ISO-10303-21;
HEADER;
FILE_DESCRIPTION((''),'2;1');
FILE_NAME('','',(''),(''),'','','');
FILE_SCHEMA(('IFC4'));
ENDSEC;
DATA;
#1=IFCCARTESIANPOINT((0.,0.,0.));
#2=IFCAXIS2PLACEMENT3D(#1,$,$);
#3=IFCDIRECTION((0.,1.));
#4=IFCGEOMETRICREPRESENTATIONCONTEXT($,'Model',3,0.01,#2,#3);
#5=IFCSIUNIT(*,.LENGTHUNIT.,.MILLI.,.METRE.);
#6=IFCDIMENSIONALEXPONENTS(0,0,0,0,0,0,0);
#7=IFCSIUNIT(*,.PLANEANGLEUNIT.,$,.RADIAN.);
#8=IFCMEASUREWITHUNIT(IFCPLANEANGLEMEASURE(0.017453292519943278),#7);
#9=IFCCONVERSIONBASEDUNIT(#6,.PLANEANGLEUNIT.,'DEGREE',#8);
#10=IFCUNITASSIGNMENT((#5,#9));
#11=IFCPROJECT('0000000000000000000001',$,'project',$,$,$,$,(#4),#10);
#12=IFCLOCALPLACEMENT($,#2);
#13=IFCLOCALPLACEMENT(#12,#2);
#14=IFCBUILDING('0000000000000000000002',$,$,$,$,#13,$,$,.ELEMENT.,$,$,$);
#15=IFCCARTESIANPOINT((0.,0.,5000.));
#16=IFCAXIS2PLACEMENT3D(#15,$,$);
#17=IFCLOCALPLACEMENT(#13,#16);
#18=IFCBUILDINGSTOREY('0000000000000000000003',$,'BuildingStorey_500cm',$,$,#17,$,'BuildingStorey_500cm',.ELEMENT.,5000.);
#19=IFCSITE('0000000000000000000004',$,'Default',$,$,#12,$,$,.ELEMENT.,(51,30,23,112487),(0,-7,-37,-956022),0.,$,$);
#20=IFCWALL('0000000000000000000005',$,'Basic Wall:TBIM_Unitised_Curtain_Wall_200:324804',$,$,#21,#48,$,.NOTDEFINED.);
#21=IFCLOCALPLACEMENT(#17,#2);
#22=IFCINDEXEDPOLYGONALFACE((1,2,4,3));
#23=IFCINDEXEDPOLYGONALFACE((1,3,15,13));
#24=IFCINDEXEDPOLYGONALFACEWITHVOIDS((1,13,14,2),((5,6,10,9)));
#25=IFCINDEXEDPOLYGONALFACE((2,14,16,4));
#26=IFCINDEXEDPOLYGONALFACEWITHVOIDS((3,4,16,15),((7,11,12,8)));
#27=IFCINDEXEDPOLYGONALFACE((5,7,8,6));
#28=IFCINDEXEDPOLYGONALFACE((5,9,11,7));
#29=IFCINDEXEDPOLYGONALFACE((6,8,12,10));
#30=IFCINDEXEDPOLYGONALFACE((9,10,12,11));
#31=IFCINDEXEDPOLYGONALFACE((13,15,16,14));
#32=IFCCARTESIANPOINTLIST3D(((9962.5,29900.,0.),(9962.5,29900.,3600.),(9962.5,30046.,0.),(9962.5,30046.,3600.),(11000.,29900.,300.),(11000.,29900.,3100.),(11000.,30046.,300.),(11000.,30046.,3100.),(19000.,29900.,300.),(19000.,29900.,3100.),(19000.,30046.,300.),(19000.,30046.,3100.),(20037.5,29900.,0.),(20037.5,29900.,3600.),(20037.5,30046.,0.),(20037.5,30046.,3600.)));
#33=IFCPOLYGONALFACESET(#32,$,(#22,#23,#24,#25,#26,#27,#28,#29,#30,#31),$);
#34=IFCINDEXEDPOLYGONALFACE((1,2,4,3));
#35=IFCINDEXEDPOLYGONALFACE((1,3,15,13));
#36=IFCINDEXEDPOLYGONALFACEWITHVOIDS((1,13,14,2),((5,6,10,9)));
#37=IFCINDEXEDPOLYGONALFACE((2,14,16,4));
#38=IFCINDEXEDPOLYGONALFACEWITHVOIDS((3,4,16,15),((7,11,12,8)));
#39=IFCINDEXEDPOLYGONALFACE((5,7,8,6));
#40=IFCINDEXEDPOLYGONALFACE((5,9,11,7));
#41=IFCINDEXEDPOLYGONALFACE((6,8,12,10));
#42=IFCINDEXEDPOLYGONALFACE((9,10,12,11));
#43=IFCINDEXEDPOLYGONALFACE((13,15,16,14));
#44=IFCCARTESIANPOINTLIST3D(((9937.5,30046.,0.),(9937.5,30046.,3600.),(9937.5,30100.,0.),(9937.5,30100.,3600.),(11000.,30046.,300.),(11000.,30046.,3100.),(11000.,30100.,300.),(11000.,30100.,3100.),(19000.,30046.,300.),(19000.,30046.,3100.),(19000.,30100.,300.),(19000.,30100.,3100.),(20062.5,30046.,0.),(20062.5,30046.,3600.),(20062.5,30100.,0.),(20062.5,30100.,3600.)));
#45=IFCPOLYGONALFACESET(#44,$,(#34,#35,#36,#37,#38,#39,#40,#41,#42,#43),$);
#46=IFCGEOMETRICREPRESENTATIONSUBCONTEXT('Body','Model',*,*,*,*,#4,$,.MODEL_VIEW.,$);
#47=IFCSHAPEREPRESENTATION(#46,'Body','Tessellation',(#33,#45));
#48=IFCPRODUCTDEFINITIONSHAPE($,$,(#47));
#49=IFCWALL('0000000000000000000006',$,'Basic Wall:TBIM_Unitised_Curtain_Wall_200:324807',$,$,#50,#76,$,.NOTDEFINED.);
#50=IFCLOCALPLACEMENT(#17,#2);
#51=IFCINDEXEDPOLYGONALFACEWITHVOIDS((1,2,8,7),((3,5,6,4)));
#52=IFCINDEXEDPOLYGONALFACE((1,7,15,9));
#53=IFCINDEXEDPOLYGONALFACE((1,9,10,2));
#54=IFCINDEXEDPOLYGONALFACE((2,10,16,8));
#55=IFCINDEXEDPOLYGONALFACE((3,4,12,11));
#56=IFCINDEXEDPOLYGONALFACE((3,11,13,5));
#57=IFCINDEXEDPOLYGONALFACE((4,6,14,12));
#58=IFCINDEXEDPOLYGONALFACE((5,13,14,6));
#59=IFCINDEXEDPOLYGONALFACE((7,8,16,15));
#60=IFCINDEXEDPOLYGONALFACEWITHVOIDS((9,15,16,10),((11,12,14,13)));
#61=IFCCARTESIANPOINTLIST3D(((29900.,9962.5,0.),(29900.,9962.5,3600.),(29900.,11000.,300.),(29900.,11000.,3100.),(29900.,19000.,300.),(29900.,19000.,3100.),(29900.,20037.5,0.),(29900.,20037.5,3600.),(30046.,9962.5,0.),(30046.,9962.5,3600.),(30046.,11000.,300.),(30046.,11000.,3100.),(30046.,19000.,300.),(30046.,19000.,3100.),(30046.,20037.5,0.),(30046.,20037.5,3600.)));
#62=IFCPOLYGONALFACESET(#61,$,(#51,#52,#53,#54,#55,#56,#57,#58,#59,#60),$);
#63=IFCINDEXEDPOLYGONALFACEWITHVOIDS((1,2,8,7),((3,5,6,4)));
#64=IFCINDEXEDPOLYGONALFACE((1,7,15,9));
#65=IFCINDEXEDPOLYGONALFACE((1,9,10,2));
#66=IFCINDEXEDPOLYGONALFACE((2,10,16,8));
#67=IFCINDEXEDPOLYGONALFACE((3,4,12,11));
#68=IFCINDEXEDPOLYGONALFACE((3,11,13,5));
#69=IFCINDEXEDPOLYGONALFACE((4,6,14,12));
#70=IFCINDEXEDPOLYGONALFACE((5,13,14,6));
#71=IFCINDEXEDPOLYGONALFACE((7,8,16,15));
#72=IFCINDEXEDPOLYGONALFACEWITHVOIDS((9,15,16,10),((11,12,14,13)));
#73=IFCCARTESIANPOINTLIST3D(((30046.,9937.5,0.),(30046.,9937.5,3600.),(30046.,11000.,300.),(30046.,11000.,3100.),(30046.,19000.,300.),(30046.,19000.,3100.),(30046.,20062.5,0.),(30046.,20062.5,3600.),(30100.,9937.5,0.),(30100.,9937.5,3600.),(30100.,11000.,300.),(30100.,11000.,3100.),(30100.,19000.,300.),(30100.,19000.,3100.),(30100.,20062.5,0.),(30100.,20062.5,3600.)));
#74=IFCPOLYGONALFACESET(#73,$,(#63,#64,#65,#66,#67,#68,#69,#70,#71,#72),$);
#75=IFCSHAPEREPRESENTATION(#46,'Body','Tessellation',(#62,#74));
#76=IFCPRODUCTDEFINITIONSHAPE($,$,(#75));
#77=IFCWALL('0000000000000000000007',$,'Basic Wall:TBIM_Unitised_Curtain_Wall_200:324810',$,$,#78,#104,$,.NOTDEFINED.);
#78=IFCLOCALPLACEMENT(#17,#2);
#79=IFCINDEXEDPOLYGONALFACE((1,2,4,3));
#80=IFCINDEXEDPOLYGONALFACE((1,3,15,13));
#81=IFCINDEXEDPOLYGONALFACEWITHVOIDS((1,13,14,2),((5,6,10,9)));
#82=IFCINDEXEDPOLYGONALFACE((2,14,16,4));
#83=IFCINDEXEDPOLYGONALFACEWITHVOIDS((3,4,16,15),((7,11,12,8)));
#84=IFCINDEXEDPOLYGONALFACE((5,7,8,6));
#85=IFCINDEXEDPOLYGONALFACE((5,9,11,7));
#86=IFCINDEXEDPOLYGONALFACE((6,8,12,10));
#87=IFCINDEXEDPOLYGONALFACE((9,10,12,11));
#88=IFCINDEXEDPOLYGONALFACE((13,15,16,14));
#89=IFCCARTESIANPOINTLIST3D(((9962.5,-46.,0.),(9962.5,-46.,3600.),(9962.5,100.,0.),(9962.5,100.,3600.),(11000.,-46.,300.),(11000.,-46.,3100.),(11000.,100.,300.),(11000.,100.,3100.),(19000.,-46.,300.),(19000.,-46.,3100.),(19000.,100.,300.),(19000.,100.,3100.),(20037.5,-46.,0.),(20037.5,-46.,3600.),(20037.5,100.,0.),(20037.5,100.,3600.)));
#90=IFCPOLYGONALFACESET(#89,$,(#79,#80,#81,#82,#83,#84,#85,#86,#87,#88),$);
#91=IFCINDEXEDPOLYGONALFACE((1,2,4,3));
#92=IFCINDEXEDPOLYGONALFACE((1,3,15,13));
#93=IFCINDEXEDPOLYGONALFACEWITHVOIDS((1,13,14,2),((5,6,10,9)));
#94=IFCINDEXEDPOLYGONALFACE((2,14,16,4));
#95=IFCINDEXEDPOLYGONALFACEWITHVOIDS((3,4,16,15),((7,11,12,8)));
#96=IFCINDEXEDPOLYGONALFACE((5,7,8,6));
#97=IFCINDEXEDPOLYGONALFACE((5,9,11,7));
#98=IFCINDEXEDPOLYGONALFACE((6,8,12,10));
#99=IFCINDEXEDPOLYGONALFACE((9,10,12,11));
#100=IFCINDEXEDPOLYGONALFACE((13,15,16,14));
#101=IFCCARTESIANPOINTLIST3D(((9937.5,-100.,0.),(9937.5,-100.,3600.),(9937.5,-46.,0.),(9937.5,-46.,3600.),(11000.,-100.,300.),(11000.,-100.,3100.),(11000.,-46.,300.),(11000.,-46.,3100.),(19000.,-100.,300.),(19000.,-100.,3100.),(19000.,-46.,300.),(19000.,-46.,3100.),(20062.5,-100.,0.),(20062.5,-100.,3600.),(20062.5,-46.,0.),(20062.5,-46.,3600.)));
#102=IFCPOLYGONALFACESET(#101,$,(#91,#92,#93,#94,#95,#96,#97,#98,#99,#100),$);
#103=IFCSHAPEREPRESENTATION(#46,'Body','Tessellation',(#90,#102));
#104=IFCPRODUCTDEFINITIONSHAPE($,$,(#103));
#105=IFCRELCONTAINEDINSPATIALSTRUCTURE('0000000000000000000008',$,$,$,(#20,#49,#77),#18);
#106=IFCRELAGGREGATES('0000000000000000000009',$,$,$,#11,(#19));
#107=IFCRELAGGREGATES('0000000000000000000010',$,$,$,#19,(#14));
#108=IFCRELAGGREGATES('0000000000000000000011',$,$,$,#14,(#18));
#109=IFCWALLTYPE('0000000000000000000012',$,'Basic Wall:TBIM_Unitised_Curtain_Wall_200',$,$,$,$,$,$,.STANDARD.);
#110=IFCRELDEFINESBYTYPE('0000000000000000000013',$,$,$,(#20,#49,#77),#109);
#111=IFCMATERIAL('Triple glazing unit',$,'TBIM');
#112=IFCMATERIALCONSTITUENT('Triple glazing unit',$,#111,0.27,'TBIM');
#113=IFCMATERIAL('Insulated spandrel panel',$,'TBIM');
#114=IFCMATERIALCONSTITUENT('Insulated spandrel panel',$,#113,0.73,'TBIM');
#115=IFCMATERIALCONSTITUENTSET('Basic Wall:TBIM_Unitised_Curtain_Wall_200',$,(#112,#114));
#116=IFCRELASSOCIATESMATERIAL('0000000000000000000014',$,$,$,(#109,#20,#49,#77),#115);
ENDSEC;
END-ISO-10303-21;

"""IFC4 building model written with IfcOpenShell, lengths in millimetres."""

from ifc_helpers import new_model, entity, si_unit, converted_unit, direction, frame, origin, place, context, subcontext, project, spatial, indexed_curve, outline, extrude, material, constituent, constituent_set, type_object, element, save


model = new_model("IFC4")

# Units and contexts
model_context = context("Model", 3, precision=0.01, world=origin(), true_north=direction((0.0, 1.0)))
body_context = subcontext(model_context, "Body", "Model", "MODEL_VIEW")
ifc_project = project(units=[si_unit("LENGTHUNIT", "METRE", prefix="MILLI"), converted_unit("PLANEANGLEUNIT", "DEGREE", entity("IfcPlaneAngleMeasure", 0.017453292519943278), si_unit("PLANEANGLEUNIT", "RADIAN"), dimensions=[0, 0, 0, 0, 0, 0, 0])], contexts=[model_context])

# Site, building, storey
site_placement = place(None, origin())
site = spatial("IfcSite", under=ifc_project, at=site_placement, Name="Default", CompositionType="ELEMENT", RefLatitude=(51, 30, 23, 112487), RefLongitude=(0, -7, -37, -956022), RefElevation=0.0)
building_placement = place(site_placement, origin())
building = spatial("IfcBuilding", under=site, at=building_placement, CompositionType="ELEMENT")
storey_placement = place(building_placement, frame((0.0, 0.0, 5000.0)))
storey = spatial("IfcBuildingStorey", under=building, at=storey_placement, Name="BuildingStorey_500cm", LongName="BuildingStorey_500cm", CompositionType="ELEMENT", Elevation=5000.0)

# Walls, openings
ifc_material_1 = material(Name="Triple glazing unit", Category="TBIM")
ifc_constituent_1 = constituent(ifc_material_1, Name="Triple glazing unit", Category="TBIM", fraction=0.27)
ifc_material_2 = material(Name="Insulated spandrel panel", Category="TBIM")
ifc_constituent_2 = constituent(ifc_material_2, Name="Insulated spandrel panel", Category="TBIM", fraction=0.73)
ifc_constituent_set_1 = constituent_set(constituents=[ifc_constituent_1, ifc_constituent_2], Name="Basic Wall:TBIM_Unitised_Curtain_Wall_200")
wall_type_1 = type_object("IfcWallType", Name="Basic Wall:TBIM_Unitised_Curtain_Wall_200", PredefinedType="STANDARD", material=ifc_constituent_set_1)
wall_1_placement = place(storey_placement, frame((9937.5, 30000.0, 0.0)))
wall_1 = element("IfcWall", 1, at=wall_1_placement, inside=storey, type_object=wall_type_1, material=ifc_constituent_set_1, Name="Basic Wall:TBIM_Unitised_Curtain_Wall_200:324804", PredefinedType="NOTDEFINED", context=body_context, shape_type="SweptSolid", body=[
    extrude(outline(indexed_curve([(-1800.0, -5037.5), (1800.0, -5037.5), (1800.0, -4937.5), (1800.0, 4937.5), (1800.0, 5037.5), (-1800.0, 5037.5), (-1800.0, 4937.5), (-1800.0, -4937.5), (-1800.0, -5037.5)], self_intersect=False), holes=[indexed_curve([(1300.0, -4000.0), (-1500.0, -4000.0), (-1500.0, 4000.0), (1300.0, 4000.0), (1300.0, -4000.0)], self_intersect=False)]), frame((5062.5, -100.0, 1800.0), z_axis=(0.0, 1.0, 0.0), x_axis=(0.0, 0.0, 1.0)), (0.0, 0.0, 1.0), 146.0),
    extrude(outline(indexed_curve([(-1800.0, -5062.5), (1800.0, -5062.5), (1800.0, 5062.5), (-1800.0, 5062.5), (-1800.0, -5062.5)], self_intersect=False), holes=[indexed_curve([(-1500.0, -4000.0), (-1500.0, 4000.0), (1300.0, 4000.0), (1300.0, -4000.0), (-1500.0, -4000.0)], self_intersect=False)]), frame((5062.5, 46.0, 1800.0), z_axis=(0.0, 1.0, 0.0), x_axis=(0.0, 0.0, 1.0)), (0.0, 0.0, 1.0), 54.0),
])
opening_1_placement = place(wall_1_placement, frame((1062.5, -100.0, 300.0)))
element("IfcOpeningElement", 2, at=opening_1_placement, cuts=wall_1, PredefinedType="OPENING", context=body_context, shape_type="SweptSolid", body=[
    extrude(outline(indexed_curve([(2800.0, 0.0), (2800.0, 8000.0), (0.0, 8000.0), (0.0, 0.0), (2800.0, 0.0)], self_intersect=False)), frame((0.0, 0.0, 0.0), z_axis=(0.0, 1.0, 0.0), x_axis=(0.0, 0.0, 1.0)), (0.0, 0.0, 1.0), 200.0),
])
wall_2_placement = place(storey_placement, frame((30000.0, 9937.5, 0.0), z_axis=(0.0, 0.0, 1.0), x_axis=(0.0, 1.0, 0.0)))
wall_2 = element("IfcWall", 3, at=wall_2_placement, inside=storey, type_object=wall_type_1, material=ifc_constituent_set_1, Name="Basic Wall:TBIM_Unitised_Curtain_Wall_200:324807", PredefinedType="NOTDEFINED", context=body_context, shape_type="SweptSolid", body=[
    extrude(outline(indexed_curve([(-5037.5, -1800.0), (-4937.5, -1800.0), (4937.5, -1800.0), (5037.5, -1800.0), (5037.5, 1800.0), (4937.5, 1800.0), (-4937.5, 1800.0), (-5037.5, 1800.0), (-5037.5, -1800.0)], self_intersect=False), holes=[indexed_curve([(-4000.0, 1300.0), (4000.0, 1300.0), (4000.0, -1500.0), (-4000.0, -1500.0), (-4000.0, 1300.0)], self_intersect=False)]), frame((5062.5, 100.0, 1800.0), z_axis=(0.0, -1.0, 0.0), x_axis=(1.0, 0.0, 0.0)), (0.0, 0.0, 1.0), 146.0),
    extrude(outline(indexed_curve([(-1800.0, -5062.5), (1800.0, -5062.5), (1800.0, 5062.5), (-1800.0, 5062.5), (-1800.0, -5062.5)], self_intersect=False), holes=[indexed_curve([(1300.0, 4000.0), (1300.0, -4000.0), (-1500.0, -4000.0), (-1500.0, 4000.0), (1300.0, 4000.0)], self_intersect=False)]), frame((5062.5, -46.0, 1800.0), z_axis=(0.0, -1.0, 0.0), x_axis=(0.0, 0.0, 1.0)), (0.0, 0.0, 1.0), 54.0),
])
opening_2_placement = place(wall_2_placement, frame((1062.5, -100.0, 300.0)))
element("IfcOpeningElement", 4, at=opening_2_placement, cuts=wall_2, PredefinedType="OPENING", context=body_context, shape_type="SweptSolid", body=[
    extrude(outline(indexed_curve([(2800.0, 0.0), (2800.0, 8000.0), (0.0, 8000.0), (0.0, 0.0), (2800.0, 0.0)], self_intersect=False)), frame((0.0, 0.0, 0.0), z_axis=(0.0, 1.0, 0.0), x_axis=(0.0, 0.0, 1.0)), (0.0, 0.0, 1.0), 200.0),
])
wall_3_placement = place(storey_placement, frame((9937.5, 0.0, 0.0)))
wall_3 = element("IfcWall", 5, at=wall_3_placement, inside=storey, type_object=wall_type_1, material=ifc_constituent_set_1, Name="Basic Wall:TBIM_Unitised_Curtain_Wall_200:324810", PredefinedType="NOTDEFINED", context=body_context, shape_type="SweptSolid", body=[
    extrude(outline(indexed_curve([(-1800.0, -5037.5), (1800.0, -5037.5), (1800.0, 5037.5), (-1800.0, 5037.5), (-1800.0, -5037.5)], self_intersect=False), holes=[indexed_curve([(-1500.0, -4000.0), (-1500.0, 4000.0), (1300.0, 4000.0), (1300.0, -4000.0), (-1500.0, -4000.0)], self_intersect=False)]), frame((5062.5, -46.0, 1800.0), z_axis=(0.0, 1.0, 0.0), x_axis=(0.0, 0.0, 1.0)), (0.0, 0.0, 1.0), 146.0),
    extrude(outline(indexed_curve([(-1800.0, -5062.5), (1800.0, -5062.5), (1800.0, 5062.5), (-1800.0, 5062.5), (-1800.0, -5062.5)], self_intersect=False), holes=[indexed_curve([(1300.0, -4000.0), (-1500.0, -4000.0), (-1500.0, 4000.0), (1300.0, 4000.0), (1300.0, -4000.0)], self_intersect=False)]), frame((5062.5, -100.0, 1800.0), z_axis=(0.0, 1.0, 0.0), x_axis=(0.0, 0.0, 1.0)), (0.0, 0.0, 1.0), 54.0),
])
opening_3_placement = place(wall_3_placement, frame((1062.5, -100.0, 300.0)))
element("IfcOpeningElement", 6, at=opening_3_placement, cuts=wall_3, PredefinedType="OPENING", context=body_context, shape_type="SweptSolid", body=[
    extrude(outline(indexed_curve([(2800.0, 0.0), (2800.0, 8000.0), (0.0, 8000.0), (0.0, 0.0), (2800.0, 0.0)], self_intersect=False)), frame((0.0, 0.0, 0.0), z_axis=(0.0, 1.0, 0.0), x_axis=(0.0, 0.0, 1.0)), (0.0, 0.0, 1.0), 200.0),
])

save(model, "model.ifc")
